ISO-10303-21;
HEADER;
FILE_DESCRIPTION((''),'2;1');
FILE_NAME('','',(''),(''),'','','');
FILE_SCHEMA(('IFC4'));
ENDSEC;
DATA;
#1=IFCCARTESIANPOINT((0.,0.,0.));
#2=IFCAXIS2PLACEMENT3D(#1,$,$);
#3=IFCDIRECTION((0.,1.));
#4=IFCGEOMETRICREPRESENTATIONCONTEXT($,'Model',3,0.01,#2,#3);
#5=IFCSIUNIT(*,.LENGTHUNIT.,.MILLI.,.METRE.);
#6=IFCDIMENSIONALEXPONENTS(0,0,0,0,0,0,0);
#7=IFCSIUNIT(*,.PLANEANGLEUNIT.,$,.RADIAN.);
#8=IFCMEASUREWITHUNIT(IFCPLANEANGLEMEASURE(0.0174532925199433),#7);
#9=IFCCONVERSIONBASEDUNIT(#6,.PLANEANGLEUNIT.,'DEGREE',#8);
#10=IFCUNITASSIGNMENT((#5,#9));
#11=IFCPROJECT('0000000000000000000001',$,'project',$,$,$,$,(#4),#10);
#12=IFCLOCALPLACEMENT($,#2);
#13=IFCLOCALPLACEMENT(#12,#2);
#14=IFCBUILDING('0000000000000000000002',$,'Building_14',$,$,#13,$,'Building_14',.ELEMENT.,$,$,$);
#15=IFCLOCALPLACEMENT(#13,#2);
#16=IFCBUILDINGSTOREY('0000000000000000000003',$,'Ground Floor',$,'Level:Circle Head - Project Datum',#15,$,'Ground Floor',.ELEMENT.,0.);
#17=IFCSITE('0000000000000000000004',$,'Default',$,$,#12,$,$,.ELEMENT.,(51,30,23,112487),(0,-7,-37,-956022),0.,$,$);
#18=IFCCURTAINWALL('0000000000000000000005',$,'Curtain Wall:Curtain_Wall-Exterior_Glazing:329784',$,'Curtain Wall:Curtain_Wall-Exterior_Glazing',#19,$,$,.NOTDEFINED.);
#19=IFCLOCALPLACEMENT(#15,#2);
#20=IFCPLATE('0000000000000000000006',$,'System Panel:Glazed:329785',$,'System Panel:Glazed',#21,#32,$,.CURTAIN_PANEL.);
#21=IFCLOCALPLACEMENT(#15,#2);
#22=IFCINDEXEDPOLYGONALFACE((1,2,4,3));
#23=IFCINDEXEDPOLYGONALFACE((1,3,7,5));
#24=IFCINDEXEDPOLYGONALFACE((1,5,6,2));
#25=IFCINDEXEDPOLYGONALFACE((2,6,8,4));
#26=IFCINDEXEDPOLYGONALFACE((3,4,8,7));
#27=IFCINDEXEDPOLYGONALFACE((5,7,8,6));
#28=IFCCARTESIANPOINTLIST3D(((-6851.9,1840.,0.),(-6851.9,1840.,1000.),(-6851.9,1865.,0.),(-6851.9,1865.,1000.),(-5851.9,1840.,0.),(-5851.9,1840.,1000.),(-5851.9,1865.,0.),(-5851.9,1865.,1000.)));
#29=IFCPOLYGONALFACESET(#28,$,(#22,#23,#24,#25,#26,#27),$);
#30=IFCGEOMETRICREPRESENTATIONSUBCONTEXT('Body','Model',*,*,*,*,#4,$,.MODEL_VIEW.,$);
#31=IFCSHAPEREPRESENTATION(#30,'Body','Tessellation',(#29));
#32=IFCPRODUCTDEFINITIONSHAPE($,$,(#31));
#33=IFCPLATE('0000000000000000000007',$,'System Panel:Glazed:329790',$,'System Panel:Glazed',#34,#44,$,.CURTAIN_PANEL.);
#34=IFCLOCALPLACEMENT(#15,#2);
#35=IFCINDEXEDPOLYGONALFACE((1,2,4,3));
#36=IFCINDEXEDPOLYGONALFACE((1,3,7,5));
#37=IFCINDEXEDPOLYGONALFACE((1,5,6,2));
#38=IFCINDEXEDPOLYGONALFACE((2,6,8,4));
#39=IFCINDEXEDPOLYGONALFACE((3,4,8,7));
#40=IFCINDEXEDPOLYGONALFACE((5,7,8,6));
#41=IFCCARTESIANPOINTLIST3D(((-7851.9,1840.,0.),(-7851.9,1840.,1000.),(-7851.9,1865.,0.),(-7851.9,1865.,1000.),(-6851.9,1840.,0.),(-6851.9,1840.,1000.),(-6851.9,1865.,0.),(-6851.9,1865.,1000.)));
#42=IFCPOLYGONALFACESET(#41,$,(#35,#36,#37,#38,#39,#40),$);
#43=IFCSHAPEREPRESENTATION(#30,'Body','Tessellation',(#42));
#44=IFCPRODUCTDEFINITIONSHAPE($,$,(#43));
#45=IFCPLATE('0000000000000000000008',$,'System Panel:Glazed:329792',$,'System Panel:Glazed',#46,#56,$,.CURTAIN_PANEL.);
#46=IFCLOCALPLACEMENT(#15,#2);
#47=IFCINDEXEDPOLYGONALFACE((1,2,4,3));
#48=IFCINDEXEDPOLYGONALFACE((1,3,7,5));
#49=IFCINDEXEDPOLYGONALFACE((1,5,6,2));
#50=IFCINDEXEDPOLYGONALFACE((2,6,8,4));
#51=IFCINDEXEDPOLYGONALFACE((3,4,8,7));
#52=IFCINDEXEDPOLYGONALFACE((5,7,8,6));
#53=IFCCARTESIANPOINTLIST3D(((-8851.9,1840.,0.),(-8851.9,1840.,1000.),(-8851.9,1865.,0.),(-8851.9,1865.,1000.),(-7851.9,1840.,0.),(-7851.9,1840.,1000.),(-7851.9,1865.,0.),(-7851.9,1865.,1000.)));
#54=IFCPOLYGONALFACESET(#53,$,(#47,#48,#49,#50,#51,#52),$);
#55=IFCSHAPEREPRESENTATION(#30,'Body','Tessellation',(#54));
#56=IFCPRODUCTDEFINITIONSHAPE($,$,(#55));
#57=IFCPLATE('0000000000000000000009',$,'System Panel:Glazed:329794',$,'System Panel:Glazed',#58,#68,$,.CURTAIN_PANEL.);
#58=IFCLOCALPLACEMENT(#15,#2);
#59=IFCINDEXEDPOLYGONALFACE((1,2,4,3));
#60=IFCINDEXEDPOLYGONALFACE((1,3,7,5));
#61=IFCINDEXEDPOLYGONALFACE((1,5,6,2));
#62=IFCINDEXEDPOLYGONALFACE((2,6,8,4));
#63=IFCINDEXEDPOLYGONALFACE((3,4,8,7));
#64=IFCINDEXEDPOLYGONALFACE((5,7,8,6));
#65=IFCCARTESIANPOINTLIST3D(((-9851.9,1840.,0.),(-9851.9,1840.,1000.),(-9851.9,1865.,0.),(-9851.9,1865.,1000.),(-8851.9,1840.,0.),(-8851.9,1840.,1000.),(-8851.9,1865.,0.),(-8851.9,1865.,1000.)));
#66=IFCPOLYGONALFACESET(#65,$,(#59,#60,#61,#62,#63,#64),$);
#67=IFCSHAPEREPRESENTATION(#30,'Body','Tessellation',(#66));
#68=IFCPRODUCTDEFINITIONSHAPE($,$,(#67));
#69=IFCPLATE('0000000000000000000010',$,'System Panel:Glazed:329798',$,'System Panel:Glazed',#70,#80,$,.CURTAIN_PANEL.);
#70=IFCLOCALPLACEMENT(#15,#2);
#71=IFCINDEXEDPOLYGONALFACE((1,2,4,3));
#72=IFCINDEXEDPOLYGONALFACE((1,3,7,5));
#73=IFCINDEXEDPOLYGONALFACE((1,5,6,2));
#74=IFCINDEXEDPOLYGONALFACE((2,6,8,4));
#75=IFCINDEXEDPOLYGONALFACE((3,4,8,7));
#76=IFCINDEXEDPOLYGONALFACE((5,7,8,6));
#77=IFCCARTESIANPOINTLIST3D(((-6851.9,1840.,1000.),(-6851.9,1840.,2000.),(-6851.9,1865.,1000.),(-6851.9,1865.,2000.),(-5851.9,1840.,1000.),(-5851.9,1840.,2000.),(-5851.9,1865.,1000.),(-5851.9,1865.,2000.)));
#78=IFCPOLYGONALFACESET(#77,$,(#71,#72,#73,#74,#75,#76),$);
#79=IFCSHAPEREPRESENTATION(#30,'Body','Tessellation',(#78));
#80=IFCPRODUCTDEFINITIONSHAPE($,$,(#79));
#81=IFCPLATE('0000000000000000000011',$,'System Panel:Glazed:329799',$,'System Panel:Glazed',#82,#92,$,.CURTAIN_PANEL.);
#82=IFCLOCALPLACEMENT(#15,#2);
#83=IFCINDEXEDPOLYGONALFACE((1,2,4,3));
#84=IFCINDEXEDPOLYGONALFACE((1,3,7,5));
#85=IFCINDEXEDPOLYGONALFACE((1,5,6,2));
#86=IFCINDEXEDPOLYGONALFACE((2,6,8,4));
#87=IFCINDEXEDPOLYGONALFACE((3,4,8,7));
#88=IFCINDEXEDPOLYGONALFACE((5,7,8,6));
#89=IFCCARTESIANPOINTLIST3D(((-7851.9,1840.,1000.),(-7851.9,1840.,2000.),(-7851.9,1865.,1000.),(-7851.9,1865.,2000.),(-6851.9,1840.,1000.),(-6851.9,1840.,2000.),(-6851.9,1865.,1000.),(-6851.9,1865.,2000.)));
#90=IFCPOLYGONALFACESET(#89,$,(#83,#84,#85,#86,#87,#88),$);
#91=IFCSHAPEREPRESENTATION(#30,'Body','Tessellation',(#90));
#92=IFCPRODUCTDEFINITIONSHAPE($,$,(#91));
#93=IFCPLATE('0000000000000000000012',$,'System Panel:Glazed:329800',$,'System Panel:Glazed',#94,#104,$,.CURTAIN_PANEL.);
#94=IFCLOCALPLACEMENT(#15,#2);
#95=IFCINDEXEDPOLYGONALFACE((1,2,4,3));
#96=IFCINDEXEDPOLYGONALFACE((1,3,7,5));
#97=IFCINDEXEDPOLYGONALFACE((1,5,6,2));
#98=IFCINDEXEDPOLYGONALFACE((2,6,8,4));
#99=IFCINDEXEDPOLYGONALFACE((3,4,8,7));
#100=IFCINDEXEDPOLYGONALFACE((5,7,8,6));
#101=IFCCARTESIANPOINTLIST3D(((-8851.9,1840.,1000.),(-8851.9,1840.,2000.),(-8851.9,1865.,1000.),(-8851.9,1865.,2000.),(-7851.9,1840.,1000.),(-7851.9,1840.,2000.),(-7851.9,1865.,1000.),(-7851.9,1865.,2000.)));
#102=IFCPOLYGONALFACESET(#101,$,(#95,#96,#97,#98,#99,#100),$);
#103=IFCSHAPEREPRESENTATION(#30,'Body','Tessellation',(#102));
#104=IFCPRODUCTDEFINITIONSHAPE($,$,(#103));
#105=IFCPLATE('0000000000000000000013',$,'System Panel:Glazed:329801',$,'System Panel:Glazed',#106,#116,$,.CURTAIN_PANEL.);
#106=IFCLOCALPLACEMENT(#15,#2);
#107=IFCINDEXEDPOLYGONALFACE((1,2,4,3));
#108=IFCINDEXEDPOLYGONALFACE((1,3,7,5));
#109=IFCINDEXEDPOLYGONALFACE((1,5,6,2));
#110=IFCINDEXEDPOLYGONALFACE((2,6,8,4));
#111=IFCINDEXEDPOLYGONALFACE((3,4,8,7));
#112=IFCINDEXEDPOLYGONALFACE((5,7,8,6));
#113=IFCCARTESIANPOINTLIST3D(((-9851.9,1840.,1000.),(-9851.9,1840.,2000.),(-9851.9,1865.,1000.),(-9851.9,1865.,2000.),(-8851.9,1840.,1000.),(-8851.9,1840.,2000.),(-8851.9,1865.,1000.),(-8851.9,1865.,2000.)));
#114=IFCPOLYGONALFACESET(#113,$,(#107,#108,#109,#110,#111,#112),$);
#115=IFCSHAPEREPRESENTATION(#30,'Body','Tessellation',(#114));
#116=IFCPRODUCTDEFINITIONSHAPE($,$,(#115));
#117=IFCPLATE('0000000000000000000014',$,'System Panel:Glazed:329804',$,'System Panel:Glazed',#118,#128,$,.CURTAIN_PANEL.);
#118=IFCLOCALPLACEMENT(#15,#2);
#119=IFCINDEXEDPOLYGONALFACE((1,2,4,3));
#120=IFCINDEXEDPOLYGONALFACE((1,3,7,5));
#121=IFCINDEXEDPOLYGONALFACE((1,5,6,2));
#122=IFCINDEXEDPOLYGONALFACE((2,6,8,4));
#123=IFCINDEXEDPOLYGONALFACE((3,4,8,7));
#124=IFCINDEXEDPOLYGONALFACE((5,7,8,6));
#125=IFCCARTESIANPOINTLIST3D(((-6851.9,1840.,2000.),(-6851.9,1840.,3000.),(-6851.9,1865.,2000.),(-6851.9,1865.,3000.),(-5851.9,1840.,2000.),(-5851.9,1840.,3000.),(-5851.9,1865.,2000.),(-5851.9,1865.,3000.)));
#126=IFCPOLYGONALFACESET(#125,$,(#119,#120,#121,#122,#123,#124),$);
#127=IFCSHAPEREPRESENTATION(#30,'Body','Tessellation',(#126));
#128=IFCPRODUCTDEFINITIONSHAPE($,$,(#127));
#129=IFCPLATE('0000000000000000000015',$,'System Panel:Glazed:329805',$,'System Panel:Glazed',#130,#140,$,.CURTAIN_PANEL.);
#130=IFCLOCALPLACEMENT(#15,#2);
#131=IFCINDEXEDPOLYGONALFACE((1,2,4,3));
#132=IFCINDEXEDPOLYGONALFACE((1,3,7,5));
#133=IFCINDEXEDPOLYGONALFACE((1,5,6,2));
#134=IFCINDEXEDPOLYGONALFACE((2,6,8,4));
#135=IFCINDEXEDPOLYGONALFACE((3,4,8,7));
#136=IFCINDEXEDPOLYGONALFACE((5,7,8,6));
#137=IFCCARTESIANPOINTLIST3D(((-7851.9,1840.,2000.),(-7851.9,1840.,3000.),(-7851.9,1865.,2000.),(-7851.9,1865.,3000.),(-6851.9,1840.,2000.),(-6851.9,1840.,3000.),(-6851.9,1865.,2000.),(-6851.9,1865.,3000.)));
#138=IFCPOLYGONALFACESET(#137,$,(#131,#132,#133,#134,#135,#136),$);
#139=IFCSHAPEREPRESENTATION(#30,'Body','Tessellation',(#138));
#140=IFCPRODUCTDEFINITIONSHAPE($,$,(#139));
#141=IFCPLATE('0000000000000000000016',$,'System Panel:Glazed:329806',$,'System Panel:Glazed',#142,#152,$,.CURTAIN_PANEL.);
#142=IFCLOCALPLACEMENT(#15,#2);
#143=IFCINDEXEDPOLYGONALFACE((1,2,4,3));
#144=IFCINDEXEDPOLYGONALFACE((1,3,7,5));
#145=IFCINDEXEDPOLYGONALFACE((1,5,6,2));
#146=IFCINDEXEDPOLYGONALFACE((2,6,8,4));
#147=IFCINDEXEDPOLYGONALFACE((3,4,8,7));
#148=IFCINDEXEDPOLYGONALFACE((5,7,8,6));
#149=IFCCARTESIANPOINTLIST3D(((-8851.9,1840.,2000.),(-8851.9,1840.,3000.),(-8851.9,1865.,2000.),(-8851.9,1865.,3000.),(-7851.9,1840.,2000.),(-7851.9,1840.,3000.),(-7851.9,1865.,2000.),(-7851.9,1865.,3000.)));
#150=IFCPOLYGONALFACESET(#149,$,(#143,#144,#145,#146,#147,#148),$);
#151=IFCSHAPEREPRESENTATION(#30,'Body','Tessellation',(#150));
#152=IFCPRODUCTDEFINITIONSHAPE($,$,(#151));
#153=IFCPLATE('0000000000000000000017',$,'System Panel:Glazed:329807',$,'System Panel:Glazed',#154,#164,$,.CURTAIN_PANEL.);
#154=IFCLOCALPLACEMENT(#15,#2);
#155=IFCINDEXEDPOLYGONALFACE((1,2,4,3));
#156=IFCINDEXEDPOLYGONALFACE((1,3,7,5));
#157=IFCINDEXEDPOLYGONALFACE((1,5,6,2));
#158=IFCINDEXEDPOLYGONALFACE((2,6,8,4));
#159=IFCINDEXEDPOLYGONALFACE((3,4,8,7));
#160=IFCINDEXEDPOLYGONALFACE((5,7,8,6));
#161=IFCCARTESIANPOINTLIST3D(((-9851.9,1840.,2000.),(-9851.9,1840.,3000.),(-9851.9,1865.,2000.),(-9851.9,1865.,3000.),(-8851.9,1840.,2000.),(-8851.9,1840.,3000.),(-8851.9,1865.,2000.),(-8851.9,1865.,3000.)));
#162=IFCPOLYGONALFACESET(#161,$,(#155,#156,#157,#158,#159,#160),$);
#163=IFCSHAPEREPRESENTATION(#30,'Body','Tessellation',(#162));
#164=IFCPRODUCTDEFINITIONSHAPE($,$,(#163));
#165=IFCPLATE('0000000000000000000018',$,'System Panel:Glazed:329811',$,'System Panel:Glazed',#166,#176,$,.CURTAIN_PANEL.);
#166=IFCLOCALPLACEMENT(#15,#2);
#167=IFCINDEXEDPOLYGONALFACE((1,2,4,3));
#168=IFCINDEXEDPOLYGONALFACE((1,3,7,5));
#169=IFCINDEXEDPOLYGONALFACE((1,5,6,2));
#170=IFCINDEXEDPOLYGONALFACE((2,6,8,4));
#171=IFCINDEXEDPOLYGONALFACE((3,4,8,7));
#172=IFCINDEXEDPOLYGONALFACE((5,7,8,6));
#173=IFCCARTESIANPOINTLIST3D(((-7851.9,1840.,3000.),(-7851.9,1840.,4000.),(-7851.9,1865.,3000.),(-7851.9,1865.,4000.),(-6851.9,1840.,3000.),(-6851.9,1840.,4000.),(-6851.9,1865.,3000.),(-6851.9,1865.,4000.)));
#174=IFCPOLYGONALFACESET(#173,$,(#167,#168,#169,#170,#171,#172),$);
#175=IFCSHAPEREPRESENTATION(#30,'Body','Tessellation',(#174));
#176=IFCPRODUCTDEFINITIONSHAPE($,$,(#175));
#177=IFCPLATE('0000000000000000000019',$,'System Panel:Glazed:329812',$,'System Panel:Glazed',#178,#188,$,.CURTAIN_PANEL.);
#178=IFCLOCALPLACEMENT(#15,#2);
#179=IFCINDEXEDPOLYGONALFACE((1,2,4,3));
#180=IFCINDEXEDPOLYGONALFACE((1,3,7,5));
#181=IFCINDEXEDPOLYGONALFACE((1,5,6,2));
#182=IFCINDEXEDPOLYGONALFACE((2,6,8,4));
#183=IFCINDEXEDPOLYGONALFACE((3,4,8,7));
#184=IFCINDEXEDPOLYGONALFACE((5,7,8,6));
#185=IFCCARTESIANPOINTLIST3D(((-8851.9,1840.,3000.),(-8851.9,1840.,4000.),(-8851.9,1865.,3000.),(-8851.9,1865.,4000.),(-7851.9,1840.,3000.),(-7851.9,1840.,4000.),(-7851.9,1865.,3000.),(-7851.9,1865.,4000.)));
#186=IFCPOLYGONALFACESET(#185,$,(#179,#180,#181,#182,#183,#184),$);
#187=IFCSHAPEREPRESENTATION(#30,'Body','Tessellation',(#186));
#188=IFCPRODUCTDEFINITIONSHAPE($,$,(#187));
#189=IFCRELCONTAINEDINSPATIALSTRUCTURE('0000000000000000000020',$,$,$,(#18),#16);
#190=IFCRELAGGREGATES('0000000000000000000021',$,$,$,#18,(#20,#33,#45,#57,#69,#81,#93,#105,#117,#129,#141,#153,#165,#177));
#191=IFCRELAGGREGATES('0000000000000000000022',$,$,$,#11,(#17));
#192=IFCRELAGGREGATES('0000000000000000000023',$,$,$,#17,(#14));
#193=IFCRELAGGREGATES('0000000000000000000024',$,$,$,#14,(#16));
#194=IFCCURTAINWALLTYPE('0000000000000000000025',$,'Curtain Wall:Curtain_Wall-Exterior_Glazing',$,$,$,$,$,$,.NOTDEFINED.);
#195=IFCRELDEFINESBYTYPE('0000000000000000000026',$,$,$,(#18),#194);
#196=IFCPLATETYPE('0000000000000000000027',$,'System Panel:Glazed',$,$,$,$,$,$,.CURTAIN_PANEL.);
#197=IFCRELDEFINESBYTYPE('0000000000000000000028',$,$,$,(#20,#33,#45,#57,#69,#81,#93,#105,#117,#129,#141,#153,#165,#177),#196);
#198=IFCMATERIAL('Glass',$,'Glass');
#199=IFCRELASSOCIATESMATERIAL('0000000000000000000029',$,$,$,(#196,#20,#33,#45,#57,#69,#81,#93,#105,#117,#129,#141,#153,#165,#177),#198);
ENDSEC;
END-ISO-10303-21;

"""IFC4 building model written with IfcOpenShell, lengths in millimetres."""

from ifc_helpers import new_model, entity, si_unit, converted_unit, direction, frame, origin, place, context, subcontext, project, spatial, indexed_curve, outline, extrude, source, transform, mapped, material, type_object, type_shapes, element, aggregate, save


model = new_model("IFC4")

# Units and contexts
model_context = context("Model", 3, precision=0.01, world=origin(), true_north=direction((0.0, 1.0)))
body_context = subcontext(model_context, "Body", "Model", "MODEL_VIEW")
ifc_project = project(units=[si_unit("LENGTHUNIT", "METRE", prefix="MILLI"), converted_unit("PLANEANGLEUNIT", "DEGREE", entity("IfcPlaneAngleMeasure", 0.0174532925199433), si_unit("PLANEANGLEUNIT", "RADIAN"), dimensions=[0, 0, 0, 0, 0, 0, 0])], contexts=[model_context])

# Site, building, storey
site_placement = place(None, origin())
site = spatial("IfcSite", under=ifc_project, at=site_placement, Name="Default", CompositionType="ELEMENT", RefLatitude=(51, 30, 23, 112487), RefLongitude=(0, -7, -37, -956022), RefElevation=0.0)
building_placement = place(site_placement, origin())
building = spatial("IfcBuilding", under=site, at=building_placement, Name="Building_14", LongName="Building_14", CompositionType="ELEMENT")
storey_placement = place(building_placement, origin())
storey = spatial("IfcBuildingStorey", under=building, at=storey_placement, Name="Ground Floor", ObjectType="Level:Circle Head - Project Datum", LongName="Ground Floor", CompositionType="ELEMENT", Elevation=0.0)

# Curtain wall, plates
curtain_wall_type = type_object("IfcCurtainWallType", Name="Curtain Wall:Curtain_Wall-Exterior_Glazing", PredefinedType="NOTDEFINED")
curtain_wall_1_placement = place(storey_placement, origin())
curtain_wall_1 = element("IfcCurtainWall", 1, at=curtain_wall_1_placement, inside=storey, type_object=curtain_wall_type, Name="Curtain Wall:Curtain_Wall-Exterior_Glazing:329784", ObjectType="Curtain Wall:Curtain_Wall-Exterior_Glazing", PredefinedType="NOTDEFINED")
ifc_material = material(Name="Glass", Category="Glass")
plate_type_1 = type_object("IfcPlateType", Name="System Panel:Glazed", PredefinedType="CURTAIN_PANEL", material=ifc_material)
shared_shape_1 = source(origin(), body_context, "Body", "SweptSolid", [
    extrude(outline(indexed_curve([(-12.5, -500.0), (12.5, -500.0), (12.5, 500.0), (-12.5, 500.0), (-12.5, -500.0)], self_intersect=False)), frame((0.0, -37.0, 0.0), z_axis=(0.0, 0.0, 1.0), x_axis=(0.0, 1.0, 0.0)), (0.0, 0.0, 1.0), 1000.0),
])
type_shapes(plate_type_1, [shared_shape_1])
plate_1_placement = place(curtain_wall_1_placement, frame((-6351.9, 1815.5, 0.0), z_axis=(0.0, 0.0, 1.0), x_axis=(-1.0, 0.0, 0.0)))
plate_1 = element("IfcPlate", 2, at=plate_1_placement, type_object=plate_type_1, material=ifc_material, Name="System Panel:Glazed:329785", ObjectType="System Panel:Glazed", PredefinedType="CURTAIN_PANEL", context=body_context, shape_type="MappedRepresentation", body=[
    mapped(shared_shape_1, transform((0.0, 0.0, 0.0), scale=1.0)),
])
plate_2_placement = place(curtain_wall_1_placement, frame((-7351.9, 1815.5, 0.0), z_axis=(0.0, 0.0, 1.0), x_axis=(-1.0, 0.0, 0.0)))
plate_2 = element("IfcPlate", 3, at=plate_2_placement, type_object=plate_type_1, material=ifc_material, Name="System Panel:Glazed:329790", ObjectType="System Panel:Glazed", PredefinedType="CURTAIN_PANEL", context=body_context, shape_type="MappedRepresentation", body=[
    mapped(shared_shape_1, transform((0.0, 0.0, 0.0), scale=1.0)),
])
plate_3_placement = place(curtain_wall_1_placement, frame((-8351.9, 1815.5, 0.0), z_axis=(0.0, 0.0, 1.0), x_axis=(-1.0, 0.0, 0.0)))
plate_3 = element("IfcPlate", 4, at=plate_3_placement, type_object=plate_type_1, material=ifc_material, Name="System Panel:Glazed:329792", ObjectType="System Panel:Glazed", PredefinedType="CURTAIN_PANEL", context=body_context, shape_type="MappedRepresentation", body=[
    mapped(shared_shape_1, transform((0.0, 0.0, 0.0), scale=1.0)),
])
plate_4_placement = place(curtain_wall_1_placement, frame((-9351.9, 1815.5, 0.0), z_axis=(0.0, 0.0, 1.0), x_axis=(-1.0, 0.0, 0.0)))
plate_4 = element("IfcPlate", 5, at=plate_4_placement, type_object=plate_type_1, material=ifc_material, Name="System Panel:Glazed:329794", ObjectType="System Panel:Glazed", PredefinedType="CURTAIN_PANEL", context=body_context, shape_type="MappedRepresentation", body=[
    mapped(shared_shape_1, transform((0.0, 0.0, 0.0), scale=1.0)),
])
plate_5_placement = place(curtain_wall_1_placement, frame((-6351.9, 1815.5, 1000.0), z_axis=(0.0, 0.0, 1.0), x_axis=(-1.0, 0.0, 0.0)))
plate_5 = element("IfcPlate", 6, at=plate_5_placement, type_object=plate_type_1, material=ifc_material, Name="System Panel:Glazed:329798", ObjectType="System Panel:Glazed", PredefinedType="CURTAIN_PANEL", context=body_context, shape_type="MappedRepresentation", body=[
    mapped(shared_shape_1, transform((0.0, 0.0, 0.0), scale=1.0)),
])
plate_6_placement = place(curtain_wall_1_placement, frame((-7351.9, 1815.5, 1000.0), z_axis=(0.0, 0.0, 1.0), x_axis=(-1.0, 0.0, 0.0)))
plate_6 = element("IfcPlate", 7, at=plate_6_placement, type_object=plate_type_1, material=ifc_material, Name="System Panel:Glazed:329799", ObjectType="System Panel:Glazed", PredefinedType="CURTAIN_PANEL", context=body_context, shape_type="MappedRepresentation", body=[
    mapped(shared_shape_1, transform((0.0, 0.0, 0.0), scale=1.0)),
])
plate_7_placement = place(curtain_wall_1_placement, frame((-8351.9, 1815.5, 1000.0), z_axis=(0.0, 0.0, 1.0), x_axis=(-1.0, 0.0, 0.0)))
plate_7 = element("IfcPlate", 8, at=plate_7_placement, type_object=plate_type_1, material=ifc_material, Name="System Panel:Glazed:329800", ObjectType="System Panel:Glazed", PredefinedType="CURTAIN_PANEL", context=body_context, shape_type="MappedRepresentation", body=[
    mapped(shared_shape_1, transform((0.0, 0.0, 0.0), scale=1.0)),
])
plate_8_placement = place(curtain_wall_1_placement, frame((-9351.9, 1815.5, 1000.0), z_axis=(0.0, 0.0, 1.0), x_axis=(-1.0, 0.0, 0.0)))
plate_8 = element("IfcPlate", 9, at=plate_8_placement, type_object=plate_type_1, material=ifc_material, Name="System Panel:Glazed:329801", ObjectType="System Panel:Glazed", PredefinedType="CURTAIN_PANEL", context=body_context, shape_type="MappedRepresentation", body=[
    mapped(shared_shape_1, transform((0.0, 0.0, 0.0), scale=1.0)),
])
plate_9_placement = place(curtain_wall_1_placement, frame((-6351.9, 1815.5, 2000.0), z_axis=(0.0, 0.0, 1.0), x_axis=(-1.0, 0.0, 0.0)))
plate_9 = element("IfcPlate", 10, at=plate_9_placement, type_object=plate_type_1, material=ifc_material, Name="System Panel:Glazed:329804", ObjectType="System Panel:Glazed", PredefinedType="CURTAIN_PANEL", context=body_context, shape_type="MappedRepresentation", body=[
    mapped(shared_shape_1, transform((0.0, 0.0, 0.0), scale=1.0)),
])
plate_10_placement = place(curtain_wall_1_placement, frame((-7351.9, 1815.5, 2000.0), z_axis=(0.0, 0.0, 1.0), x_axis=(-1.0, 0.0, 0.0)))
plate_10 = element("IfcPlate", 11, at=plate_10_placement, type_object=plate_type_1, material=ifc_material, Name="System Panel:Glazed:329805", ObjectType="System Panel:Glazed", PredefinedType="CURTAIN_PANEL", context=body_context, shape_type="MappedRepresentation", body=[
    mapped(shared_shape_1, transform((0.0, 0.0, 0.0), scale=1.0)),
])
plate_11_placement = place(curtain_wall_1_placement, frame((-8351.9, 1815.5, 2000.0), z_axis=(0.0, 0.0, 1.0), x_axis=(-1.0, 0.0, 0.0)))
plate_11 = element("IfcPlate", 12, at=plate_11_placement, type_object=plate_type_1, material=ifc_material, Name="System Panel:Glazed:329806", ObjectType="System Panel:Glazed", PredefinedType="CURTAIN_PANEL", context=body_context, shape_type="MappedRepresentation", body=[
    mapped(shared_shape_1, transform((0.0, 0.0, 0.0), scale=1.0)),
])
plate_12_placement = place(curtain_wall_1_placement, frame((-9351.9, 1815.5, 2000.0), z_axis=(0.0, 0.0, 1.0), x_axis=(-1.0, 0.0, 0.0)))
plate_12 = element("IfcPlate", 13, at=plate_12_placement, type_object=plate_type_1, material=ifc_material, Name="System Panel:Glazed:329807", ObjectType="System Panel:Glazed", PredefinedType="CURTAIN_PANEL", context=body_context, shape_type="MappedRepresentation", body=[
    mapped(shared_shape_1, transform((0.0, 0.0, 0.0), scale=1.0)),
])
plate_13_placement = place(curtain_wall_1_placement, frame((-7351.9, 1815.5, 3000.0), z_axis=(0.0, 0.0, 1.0), x_axis=(-1.0, 0.0, 0.0)))
plate_13 = element("IfcPlate", 14, at=plate_13_placement, type_object=plate_type_1, material=ifc_material, Name="System Panel:Glazed:329811", ObjectType="System Panel:Glazed", PredefinedType="CURTAIN_PANEL", context=body_context, shape_type="MappedRepresentation", body=[
    mapped(shared_shape_1, transform((0.0, 0.0, 0.0), scale=1.0)),
])
plate_14_placement = place(curtain_wall_1_placement, frame((-8351.9, 1815.5, 3000.0), z_axis=(0.0, 0.0, 1.0), x_axis=(-1.0, 0.0, 0.0)))
plate_14 = element("IfcPlate", 15, at=plate_14_placement, type_object=plate_type_1, material=ifc_material, Name="System Panel:Glazed:329812", ObjectType="System Panel:Glazed", PredefinedType="CURTAIN_PANEL", context=body_context, shape_type="MappedRepresentation", body=[
    mapped(shared_shape_1, transform((0.0, 0.0, 0.0), scale=1.0)),
])
aggregate(curtain_wall_1, [plate_1, plate_2, plate_3, plate_4, plate_5, plate_6, plate_7, plate_8, plate_9, plate_10, plate_11, plate_12, plate_13, plate_14])

save(model, "model.ifc")
